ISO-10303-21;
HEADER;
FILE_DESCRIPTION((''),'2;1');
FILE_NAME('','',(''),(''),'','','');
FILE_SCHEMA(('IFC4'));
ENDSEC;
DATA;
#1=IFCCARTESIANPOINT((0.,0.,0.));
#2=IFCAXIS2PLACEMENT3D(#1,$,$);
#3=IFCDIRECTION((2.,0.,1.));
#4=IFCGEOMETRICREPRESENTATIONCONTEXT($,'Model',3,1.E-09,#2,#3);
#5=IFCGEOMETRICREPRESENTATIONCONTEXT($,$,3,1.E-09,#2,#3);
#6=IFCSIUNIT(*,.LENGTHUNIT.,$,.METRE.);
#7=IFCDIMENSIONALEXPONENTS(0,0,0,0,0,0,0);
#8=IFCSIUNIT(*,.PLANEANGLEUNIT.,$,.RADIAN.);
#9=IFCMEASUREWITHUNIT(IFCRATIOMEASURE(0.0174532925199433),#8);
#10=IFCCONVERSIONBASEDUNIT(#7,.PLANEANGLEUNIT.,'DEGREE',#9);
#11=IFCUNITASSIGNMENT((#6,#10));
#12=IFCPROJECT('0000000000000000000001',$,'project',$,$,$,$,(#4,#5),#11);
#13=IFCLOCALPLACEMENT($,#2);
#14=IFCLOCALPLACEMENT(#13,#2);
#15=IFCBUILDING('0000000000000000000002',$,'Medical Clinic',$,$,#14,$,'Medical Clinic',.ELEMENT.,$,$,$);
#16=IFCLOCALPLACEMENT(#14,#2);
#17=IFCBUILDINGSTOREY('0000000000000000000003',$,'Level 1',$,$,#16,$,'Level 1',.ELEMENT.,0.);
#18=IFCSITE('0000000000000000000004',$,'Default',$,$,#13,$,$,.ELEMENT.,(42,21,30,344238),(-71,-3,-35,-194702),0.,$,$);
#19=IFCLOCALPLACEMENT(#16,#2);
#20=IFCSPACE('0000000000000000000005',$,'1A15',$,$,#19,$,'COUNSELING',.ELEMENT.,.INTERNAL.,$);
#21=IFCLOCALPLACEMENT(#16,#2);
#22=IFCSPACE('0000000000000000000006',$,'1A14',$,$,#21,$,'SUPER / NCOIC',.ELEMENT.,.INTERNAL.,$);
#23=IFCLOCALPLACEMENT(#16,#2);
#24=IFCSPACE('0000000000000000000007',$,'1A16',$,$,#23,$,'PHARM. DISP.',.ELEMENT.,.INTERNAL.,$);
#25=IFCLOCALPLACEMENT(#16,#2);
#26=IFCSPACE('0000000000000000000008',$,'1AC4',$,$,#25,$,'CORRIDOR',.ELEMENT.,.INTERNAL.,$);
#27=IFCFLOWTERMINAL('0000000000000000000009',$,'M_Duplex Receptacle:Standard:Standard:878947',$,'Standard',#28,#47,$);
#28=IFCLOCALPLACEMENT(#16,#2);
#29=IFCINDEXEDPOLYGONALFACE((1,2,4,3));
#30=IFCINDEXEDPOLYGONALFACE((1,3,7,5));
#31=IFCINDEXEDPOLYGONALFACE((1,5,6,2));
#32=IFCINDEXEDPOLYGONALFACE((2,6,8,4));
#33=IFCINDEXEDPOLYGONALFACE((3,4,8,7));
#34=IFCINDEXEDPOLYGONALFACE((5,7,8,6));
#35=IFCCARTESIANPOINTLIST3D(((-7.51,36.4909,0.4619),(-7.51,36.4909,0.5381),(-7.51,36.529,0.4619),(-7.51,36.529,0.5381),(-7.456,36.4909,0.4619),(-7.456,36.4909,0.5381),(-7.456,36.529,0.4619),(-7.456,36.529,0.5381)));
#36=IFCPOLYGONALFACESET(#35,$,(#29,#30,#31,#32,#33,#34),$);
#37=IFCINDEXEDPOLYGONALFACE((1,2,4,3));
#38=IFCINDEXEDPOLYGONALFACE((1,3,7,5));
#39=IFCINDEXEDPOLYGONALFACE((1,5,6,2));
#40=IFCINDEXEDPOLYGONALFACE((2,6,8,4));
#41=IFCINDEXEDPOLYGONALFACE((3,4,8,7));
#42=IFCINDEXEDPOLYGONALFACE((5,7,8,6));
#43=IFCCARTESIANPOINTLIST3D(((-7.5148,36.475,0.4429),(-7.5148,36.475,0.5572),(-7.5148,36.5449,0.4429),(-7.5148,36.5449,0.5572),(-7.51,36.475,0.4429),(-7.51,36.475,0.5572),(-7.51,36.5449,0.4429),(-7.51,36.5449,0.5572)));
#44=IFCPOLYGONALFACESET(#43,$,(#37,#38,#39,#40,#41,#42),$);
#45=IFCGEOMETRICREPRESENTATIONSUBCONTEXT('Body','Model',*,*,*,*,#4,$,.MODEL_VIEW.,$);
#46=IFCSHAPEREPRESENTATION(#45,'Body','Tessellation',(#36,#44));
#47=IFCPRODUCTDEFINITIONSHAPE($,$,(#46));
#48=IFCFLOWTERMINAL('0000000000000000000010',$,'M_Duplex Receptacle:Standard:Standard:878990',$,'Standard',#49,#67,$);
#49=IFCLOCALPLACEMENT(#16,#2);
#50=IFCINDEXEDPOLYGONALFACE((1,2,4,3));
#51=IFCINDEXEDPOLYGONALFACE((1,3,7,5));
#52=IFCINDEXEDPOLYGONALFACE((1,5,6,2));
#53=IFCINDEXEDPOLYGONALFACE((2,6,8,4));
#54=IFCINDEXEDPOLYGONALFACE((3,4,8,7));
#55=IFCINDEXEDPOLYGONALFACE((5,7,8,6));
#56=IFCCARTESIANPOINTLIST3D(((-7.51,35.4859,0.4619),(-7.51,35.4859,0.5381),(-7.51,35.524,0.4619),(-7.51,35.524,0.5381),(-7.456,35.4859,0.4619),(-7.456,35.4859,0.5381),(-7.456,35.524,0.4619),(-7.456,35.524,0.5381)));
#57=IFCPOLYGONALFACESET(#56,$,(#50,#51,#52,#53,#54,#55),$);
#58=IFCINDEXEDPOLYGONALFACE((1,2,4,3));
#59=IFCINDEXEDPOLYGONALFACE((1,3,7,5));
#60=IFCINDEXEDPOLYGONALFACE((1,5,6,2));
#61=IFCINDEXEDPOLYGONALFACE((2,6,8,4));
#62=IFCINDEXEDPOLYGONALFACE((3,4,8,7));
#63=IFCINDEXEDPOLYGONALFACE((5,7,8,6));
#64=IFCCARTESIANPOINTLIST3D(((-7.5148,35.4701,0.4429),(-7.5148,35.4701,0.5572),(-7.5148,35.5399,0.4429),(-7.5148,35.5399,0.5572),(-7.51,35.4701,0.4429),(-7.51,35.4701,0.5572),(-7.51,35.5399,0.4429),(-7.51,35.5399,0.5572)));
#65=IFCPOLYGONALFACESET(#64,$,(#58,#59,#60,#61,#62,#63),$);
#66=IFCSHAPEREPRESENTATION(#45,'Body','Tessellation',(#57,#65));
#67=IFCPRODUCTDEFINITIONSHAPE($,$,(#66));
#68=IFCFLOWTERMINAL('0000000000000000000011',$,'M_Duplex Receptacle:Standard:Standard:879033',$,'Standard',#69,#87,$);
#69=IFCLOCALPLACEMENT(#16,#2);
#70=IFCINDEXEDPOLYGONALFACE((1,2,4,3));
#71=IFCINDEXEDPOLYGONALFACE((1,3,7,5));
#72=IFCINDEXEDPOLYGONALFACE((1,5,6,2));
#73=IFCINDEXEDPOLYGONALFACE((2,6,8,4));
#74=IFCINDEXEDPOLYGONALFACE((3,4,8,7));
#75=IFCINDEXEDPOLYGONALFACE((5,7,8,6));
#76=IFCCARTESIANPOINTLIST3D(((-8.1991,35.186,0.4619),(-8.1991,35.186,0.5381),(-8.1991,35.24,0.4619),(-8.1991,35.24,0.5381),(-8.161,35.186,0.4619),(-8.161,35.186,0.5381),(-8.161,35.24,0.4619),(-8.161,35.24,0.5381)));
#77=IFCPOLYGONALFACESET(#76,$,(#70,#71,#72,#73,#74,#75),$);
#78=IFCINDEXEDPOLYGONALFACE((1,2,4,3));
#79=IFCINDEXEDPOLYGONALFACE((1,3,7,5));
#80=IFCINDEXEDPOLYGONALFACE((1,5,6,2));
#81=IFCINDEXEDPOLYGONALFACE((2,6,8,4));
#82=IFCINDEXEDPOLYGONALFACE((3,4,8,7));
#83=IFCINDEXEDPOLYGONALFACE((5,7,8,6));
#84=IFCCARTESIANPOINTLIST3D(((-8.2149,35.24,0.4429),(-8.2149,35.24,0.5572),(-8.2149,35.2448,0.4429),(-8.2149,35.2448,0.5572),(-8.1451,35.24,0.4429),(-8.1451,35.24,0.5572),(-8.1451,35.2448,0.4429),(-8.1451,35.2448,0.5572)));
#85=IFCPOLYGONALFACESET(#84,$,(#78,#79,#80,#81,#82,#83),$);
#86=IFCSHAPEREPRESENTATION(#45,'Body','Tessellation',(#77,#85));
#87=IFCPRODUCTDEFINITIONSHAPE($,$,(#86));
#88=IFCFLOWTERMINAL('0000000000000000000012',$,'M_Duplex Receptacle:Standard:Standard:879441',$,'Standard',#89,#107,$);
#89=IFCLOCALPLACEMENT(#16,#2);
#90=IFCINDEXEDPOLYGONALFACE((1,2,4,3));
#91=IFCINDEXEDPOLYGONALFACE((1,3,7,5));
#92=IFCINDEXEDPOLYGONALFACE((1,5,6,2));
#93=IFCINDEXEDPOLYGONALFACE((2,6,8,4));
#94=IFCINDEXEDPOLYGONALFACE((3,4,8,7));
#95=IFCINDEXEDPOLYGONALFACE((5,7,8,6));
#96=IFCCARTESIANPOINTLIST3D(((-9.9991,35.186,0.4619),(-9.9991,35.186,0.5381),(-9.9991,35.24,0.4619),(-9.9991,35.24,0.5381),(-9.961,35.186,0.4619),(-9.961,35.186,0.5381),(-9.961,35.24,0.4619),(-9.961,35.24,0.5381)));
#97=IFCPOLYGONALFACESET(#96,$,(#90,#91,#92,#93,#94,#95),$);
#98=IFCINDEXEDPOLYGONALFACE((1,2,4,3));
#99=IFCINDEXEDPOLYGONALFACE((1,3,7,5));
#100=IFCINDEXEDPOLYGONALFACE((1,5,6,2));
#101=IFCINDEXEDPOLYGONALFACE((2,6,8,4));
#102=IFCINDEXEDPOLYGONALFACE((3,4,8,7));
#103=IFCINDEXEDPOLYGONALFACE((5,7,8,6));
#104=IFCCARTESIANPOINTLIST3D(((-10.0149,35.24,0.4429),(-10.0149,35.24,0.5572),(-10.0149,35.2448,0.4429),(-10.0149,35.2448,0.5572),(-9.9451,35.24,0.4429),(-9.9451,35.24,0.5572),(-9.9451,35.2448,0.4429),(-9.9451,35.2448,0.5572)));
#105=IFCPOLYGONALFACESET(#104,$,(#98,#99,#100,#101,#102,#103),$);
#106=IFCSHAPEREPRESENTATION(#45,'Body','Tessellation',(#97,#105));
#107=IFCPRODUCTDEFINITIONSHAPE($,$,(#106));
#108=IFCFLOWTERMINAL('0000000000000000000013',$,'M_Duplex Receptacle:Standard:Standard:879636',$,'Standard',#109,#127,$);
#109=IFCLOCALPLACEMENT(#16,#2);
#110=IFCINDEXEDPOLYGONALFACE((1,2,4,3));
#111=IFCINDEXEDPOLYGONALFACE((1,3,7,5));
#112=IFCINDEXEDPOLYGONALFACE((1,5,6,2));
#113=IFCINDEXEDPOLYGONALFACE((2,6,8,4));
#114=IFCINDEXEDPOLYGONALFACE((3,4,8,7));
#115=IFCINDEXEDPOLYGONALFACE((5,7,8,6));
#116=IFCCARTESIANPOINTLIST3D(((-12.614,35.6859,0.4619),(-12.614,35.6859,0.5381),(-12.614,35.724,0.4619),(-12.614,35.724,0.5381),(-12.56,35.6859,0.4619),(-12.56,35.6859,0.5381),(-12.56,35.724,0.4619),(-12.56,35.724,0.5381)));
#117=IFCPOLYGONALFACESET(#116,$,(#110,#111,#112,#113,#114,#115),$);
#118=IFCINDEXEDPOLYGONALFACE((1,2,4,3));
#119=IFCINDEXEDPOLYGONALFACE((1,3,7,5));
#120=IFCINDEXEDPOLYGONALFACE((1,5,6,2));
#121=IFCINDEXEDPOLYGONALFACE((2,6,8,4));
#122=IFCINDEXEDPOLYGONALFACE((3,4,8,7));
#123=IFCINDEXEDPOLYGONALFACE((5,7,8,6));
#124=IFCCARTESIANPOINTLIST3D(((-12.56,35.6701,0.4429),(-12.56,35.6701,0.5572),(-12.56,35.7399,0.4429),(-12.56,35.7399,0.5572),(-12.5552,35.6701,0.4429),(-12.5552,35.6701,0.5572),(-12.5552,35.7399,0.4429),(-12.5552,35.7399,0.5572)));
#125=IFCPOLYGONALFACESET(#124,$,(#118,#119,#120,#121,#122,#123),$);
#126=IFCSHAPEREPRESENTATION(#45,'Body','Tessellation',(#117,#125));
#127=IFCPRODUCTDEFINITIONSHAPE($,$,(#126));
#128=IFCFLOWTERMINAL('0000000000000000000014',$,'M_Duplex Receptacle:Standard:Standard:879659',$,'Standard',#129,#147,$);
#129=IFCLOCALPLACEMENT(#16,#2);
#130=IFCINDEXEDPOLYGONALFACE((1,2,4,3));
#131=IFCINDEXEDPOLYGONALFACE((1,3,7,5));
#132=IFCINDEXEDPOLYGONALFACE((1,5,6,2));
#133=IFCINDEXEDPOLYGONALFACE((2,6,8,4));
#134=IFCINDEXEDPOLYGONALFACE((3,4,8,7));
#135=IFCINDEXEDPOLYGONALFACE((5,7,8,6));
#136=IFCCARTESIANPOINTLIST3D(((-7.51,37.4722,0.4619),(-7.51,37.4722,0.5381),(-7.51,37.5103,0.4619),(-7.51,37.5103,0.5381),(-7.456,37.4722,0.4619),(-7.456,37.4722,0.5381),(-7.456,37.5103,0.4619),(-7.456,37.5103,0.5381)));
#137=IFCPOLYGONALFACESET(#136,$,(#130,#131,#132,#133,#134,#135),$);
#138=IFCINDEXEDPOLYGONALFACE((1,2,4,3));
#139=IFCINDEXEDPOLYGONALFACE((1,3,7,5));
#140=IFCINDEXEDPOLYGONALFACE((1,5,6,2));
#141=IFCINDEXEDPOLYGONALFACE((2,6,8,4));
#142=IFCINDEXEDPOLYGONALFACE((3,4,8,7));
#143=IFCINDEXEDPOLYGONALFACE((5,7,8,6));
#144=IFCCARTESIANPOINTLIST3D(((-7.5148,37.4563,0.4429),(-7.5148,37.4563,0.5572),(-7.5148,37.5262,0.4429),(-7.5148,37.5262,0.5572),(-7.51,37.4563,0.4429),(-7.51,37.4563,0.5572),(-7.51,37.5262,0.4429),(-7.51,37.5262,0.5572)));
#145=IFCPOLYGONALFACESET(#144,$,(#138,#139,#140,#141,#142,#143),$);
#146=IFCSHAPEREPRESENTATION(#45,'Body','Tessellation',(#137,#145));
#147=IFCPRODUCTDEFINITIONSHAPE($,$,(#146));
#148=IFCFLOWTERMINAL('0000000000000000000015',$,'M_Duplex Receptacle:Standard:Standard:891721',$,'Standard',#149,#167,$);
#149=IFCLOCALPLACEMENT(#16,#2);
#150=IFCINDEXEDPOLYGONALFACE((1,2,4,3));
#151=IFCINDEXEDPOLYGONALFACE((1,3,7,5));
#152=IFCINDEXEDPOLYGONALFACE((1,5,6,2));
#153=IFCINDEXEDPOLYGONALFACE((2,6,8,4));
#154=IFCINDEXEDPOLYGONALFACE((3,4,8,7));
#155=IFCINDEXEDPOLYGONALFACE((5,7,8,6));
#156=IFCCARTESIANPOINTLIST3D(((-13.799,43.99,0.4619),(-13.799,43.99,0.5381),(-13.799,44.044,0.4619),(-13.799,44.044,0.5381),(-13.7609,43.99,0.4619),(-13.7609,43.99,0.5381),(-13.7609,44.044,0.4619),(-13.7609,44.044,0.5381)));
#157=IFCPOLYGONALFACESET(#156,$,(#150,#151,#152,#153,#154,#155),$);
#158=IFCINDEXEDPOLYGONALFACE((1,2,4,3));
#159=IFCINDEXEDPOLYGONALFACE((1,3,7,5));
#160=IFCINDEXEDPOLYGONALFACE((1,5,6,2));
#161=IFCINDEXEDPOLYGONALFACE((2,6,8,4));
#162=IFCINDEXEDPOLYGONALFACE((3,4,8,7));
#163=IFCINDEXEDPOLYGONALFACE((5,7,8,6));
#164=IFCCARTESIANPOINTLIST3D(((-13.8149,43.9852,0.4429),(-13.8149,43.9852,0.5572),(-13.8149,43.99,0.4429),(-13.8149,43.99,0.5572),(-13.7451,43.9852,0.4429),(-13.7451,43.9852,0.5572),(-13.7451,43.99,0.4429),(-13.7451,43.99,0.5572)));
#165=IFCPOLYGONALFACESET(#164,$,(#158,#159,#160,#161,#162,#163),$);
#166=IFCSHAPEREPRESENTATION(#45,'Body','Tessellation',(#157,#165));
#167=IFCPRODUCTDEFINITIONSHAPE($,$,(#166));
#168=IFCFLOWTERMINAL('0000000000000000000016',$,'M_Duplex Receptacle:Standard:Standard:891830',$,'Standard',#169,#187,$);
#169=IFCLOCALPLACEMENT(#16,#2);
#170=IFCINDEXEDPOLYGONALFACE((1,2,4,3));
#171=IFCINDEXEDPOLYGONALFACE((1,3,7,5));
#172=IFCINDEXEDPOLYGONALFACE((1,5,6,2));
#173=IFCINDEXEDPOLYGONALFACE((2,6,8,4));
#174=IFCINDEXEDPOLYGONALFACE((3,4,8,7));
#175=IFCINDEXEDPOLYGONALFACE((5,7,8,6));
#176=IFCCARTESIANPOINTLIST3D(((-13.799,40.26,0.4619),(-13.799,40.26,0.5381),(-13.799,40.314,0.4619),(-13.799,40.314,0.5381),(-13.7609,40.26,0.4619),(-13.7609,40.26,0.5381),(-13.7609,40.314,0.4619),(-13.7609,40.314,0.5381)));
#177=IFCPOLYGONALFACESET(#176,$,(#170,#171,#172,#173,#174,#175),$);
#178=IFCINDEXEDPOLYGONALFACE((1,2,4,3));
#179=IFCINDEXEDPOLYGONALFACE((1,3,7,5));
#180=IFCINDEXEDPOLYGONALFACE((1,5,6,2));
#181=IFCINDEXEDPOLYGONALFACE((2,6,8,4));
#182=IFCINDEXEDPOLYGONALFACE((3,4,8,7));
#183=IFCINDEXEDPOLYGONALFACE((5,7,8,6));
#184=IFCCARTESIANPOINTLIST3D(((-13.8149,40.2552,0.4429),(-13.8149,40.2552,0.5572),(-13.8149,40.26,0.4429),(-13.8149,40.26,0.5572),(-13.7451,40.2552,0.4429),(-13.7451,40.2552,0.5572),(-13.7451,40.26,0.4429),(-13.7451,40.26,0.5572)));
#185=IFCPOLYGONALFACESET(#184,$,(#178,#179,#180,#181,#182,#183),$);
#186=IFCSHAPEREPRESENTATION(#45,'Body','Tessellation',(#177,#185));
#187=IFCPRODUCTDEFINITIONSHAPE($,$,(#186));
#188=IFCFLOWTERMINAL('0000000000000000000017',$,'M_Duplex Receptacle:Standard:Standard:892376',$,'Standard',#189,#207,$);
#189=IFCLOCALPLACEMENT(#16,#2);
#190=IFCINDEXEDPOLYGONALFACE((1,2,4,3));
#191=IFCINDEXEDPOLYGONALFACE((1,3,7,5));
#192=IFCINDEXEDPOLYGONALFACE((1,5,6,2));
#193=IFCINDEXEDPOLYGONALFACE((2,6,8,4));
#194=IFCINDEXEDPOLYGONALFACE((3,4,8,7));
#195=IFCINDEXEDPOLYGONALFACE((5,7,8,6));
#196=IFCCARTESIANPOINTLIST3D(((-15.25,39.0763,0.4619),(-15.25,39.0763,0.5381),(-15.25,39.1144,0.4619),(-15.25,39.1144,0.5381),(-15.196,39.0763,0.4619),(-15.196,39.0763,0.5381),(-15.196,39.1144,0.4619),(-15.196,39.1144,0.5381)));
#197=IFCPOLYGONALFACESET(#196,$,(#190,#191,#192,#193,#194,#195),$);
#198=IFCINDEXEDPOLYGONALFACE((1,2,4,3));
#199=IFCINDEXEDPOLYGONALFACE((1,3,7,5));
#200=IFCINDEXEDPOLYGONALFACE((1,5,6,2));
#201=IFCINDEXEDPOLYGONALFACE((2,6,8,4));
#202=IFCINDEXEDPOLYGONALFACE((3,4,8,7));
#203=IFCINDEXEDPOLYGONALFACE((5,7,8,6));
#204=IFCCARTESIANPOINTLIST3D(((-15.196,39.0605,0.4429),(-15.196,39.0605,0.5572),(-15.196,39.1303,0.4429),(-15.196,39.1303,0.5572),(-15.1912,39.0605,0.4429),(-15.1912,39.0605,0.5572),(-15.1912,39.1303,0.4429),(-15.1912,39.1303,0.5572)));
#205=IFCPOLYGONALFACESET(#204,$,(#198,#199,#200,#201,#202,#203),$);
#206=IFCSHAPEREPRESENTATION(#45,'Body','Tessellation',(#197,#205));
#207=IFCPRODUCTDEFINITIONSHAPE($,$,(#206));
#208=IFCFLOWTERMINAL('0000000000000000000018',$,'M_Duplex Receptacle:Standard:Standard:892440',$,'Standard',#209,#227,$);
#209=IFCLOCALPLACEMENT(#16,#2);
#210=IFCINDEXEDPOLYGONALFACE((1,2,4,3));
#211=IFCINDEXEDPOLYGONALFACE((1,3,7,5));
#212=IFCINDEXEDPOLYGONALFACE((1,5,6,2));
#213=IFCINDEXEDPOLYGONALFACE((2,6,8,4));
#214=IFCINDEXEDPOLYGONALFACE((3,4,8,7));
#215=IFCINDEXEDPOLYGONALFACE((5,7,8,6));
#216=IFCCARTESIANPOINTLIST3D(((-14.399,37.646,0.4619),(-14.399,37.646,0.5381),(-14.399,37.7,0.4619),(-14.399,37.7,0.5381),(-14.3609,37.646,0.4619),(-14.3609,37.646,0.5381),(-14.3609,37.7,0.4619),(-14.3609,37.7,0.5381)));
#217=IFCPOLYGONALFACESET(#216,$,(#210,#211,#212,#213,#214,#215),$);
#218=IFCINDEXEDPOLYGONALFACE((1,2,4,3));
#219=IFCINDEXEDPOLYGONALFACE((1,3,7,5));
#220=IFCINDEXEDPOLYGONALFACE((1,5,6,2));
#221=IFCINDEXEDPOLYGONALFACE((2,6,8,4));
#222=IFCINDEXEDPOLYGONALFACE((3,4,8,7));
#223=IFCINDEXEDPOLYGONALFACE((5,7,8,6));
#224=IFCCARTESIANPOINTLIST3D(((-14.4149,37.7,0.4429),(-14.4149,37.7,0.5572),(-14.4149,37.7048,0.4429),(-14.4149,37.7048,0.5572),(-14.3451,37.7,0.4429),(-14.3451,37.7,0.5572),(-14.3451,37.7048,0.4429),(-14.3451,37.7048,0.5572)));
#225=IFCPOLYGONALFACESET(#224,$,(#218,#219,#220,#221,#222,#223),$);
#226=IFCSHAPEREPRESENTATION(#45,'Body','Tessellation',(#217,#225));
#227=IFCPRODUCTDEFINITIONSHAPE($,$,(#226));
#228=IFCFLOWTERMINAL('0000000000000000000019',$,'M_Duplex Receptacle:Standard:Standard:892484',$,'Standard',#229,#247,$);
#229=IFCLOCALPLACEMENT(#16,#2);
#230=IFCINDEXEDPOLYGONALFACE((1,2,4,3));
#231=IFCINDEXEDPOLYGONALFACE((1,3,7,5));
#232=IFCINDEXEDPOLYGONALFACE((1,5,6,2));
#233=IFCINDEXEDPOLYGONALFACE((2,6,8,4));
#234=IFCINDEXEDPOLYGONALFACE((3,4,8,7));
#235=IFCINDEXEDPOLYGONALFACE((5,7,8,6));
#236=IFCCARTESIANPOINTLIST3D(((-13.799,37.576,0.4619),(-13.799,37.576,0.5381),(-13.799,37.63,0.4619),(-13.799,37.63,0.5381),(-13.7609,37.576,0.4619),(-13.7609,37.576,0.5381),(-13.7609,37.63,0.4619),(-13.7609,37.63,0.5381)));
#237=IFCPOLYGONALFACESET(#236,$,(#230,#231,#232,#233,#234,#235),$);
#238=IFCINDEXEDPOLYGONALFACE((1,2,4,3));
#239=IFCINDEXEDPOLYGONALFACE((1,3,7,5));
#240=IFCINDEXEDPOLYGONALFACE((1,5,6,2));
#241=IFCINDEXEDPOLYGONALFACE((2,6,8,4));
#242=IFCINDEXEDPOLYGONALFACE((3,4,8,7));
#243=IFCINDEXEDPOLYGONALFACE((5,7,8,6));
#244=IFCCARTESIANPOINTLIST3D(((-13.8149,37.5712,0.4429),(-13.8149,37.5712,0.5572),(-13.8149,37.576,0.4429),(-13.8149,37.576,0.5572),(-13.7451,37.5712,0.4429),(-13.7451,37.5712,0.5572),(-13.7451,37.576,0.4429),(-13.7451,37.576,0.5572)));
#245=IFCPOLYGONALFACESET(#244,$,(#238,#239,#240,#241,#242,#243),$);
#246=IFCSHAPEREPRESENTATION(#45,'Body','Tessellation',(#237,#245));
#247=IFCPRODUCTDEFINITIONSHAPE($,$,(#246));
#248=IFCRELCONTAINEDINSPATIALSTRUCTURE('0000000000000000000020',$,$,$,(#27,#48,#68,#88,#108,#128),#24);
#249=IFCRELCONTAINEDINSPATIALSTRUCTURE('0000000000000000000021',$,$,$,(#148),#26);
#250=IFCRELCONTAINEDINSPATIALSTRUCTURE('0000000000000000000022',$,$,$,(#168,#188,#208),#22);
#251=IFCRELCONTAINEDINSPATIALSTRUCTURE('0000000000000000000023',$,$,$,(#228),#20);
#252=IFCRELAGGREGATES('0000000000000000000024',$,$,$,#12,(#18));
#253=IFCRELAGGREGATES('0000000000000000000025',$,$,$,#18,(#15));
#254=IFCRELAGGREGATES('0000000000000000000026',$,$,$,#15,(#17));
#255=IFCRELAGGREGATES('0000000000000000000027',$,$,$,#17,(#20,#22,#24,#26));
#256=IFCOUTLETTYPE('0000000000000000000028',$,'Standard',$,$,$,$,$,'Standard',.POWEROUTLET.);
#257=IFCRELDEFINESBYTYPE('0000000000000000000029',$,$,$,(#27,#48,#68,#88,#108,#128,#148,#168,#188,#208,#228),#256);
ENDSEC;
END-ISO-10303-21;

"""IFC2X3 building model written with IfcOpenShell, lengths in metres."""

from ifc_helpers import new_model, entity, si_unit, converted_unit, direction, frame, frame_2d, origin, origin_2d_with_axis, place, context, subcontext, project, spatial, rectangle, extrude, source, transform, mapped, type_object, type_shapes, element, save


model = new_model("IFC2X3")

# Units and contexts
model_context = context("Model", 3, precision=1e-09, world=origin(), true_north=direction((2.0, 0.0, 1.0)))
context_of_model = context(None, 3, precision=1e-09, world=origin(), true_north=direction((2.0, 0.0, 1.0)))
body_context = subcontext(model_context, "Body", "Model", "MODEL_VIEW")
ifc_project = project(units=[si_unit("LENGTHUNIT", "METRE"), converted_unit("PLANEANGLEUNIT", "DEGREE", entity("IfcRatioMeasure", 0.0174532925199433), si_unit("PLANEANGLEUNIT", "RADIAN"), dimensions=[0, 0, 0, 0, 0, 0, 0])], contexts=[model_context, context_of_model])

# Site, building, storey
site_placement = place(None, origin())
site = spatial("IfcSite", under=ifc_project, at=site_placement, Name="Default", CompositionType="ELEMENT", RefLatitude=(42, 21, 30, 344238), RefLongitude=(-71, -3, -35, -194702), RefElevation=0.0)
building_placement = place(site_placement, origin())
building = spatial("IfcBuilding", under=site, at=building_placement, Name="Medical Clinic", LongName="Medical Clinic", CompositionType="ELEMENT")
storey_placement = place(building_placement, origin())
storey = spatial("IfcBuildingStorey", under=building, at=storey_placement, Name="Level 1", LongName="Level 1", CompositionType="ELEMENT", Elevation=0.0)

# Shared definitions
space_1_placement = place(storey_placement, origin())
space_1 = spatial("IfcSpace", under=storey, at=space_1_placement, Name="1A15", LongName="COUNSELING", CompositionType="ELEMENT", InteriorOrExteriorSpace="INTERNAL")

# Shared definitions
space_2_placement = place(storey_placement, origin())
space_2 = spatial("IfcSpace", under=storey, at=space_2_placement, Name="1A14", LongName="SUPER / NCOIC", CompositionType="ELEMENT", InteriorOrExteriorSpace="INTERNAL")

# Shared definitions
space_3_placement = place(storey_placement, origin())
space_3 = spatial("IfcSpace", under=storey, at=space_3_placement, Name="1A16", LongName="PHARM. DISP.", CompositionType="ELEMENT", InteriorOrExteriorSpace="INTERNAL")

# Flow terminals
outlet_type = type_object("IfcOutletType", Name="Standard", ElementType="Standard", PredefinedType="POWEROUTLET")
shared_shape_1 = source(origin(), body_context, "Body", "SweptSolid", [
    extrude(rectangle(XDim=0.0381, YDim=0.0762, at=origin_2d_with_axis()), frame((0.0, 0.0, -0.054), z_axis=(0.0, 0.0, 1.0), x_axis=(-1.0, 0.0, 0.0)), (0.0, 0.0, 1.0), 0.054),
    extrude(rectangle(XDim=0.0698, YDim=0.1143, at=frame_2d((0.0, 0.0), x_axis=(1.0, 0.0))), frame((0.0, 0.0, 0.0), z_axis=(0.0, 0.0, 1.0), x_axis=(-1.0, 0.0, 0.0)), (0.0, 0.0, 1.0), 0.0048),
])
type_shapes(outlet_type, [shared_shape_1])
for number, where, z_axis, x_axis, name in (
    (1, (-7.51, 36.5099, 0.5), (-1.0, 0.0, 0.0), (0.0, -1.0, 0.0), "M_Duplex Receptacle:Standard:Standard:878947"),
    (2, (-7.51, 35.505, 0.5), (-1.0, 0.0, 0.0), (0.0, -1.0, 0.0), "M_Duplex Receptacle:Standard:Standard:878990"),
    (3, (-8.18, 35.24, 0.5), (0.0, 1.0, 0.0), (-1.0, 0.0, 0.0), "M_Duplex Receptacle:Standard:Standard:879033"),
    (4, (-9.98, 35.24, 0.5), (0.0, 1.0, 0.0), (-1.0, 0.0, 0.0), "M_Duplex Receptacle:Standard:Standard:879441"),
    (5, (-12.56, 35.705, 0.5), (1.0, 0.0, 0.0), (0.0, 1.0, 0.0), "M_Duplex Receptacle:Standard:Standard:879636"),
    (6, (-7.51, 37.4912, 0.5), (-1.0, 0.0, 0.0), (0.0, -1.0, 0.0), "M_Duplex Receptacle:Standard:Standard:879659"),
):
    element("IfcFlowTerminal", number, at=place(space_3_placement, frame(where, z_axis=z_axis, x_axis=x_axis)), inside=space_3, type_object=outlet_type, Name=name, ObjectType="Standard", context=body_context, shape_type="MappedRepresentation", body=[
        mapped(shared_shape_1, transform((0.0, 0.0, 0.0), scale=1.0)),
    ])

# Shared definitions
space_4_placement = place(storey_placement, origin())
space_4 = spatial("IfcSpace", under=storey, at=space_4_placement, Name="1AC4", LongName="CORRIDOR", CompositionType="ELEMENT", InteriorOrExteriorSpace="INTERNAL")

# Flow terminals
flow_terminal_1_placement = place(space_4_placement, frame((-13.78, 43.99, 0.5), z_axis=(0.0, -1.0, 0.0), x_axis=(1.0, 0.0, 0.0)))
element("IfcFlowTerminal", 7, at=flow_terminal_1_placement, inside=space_4, type_object=outlet_type, Name="M_Duplex Receptacle:Standard:Standard:891721", ObjectType="Standard", context=body_context, shape_type="MappedRepresentation", body=[
    mapped(shared_shape_1, transform((0.0, 0.0, 0.0), scale=1.0)),
])
for number, where, z_axis, x_axis, name in (
    (8, (-13.78, 40.26, 0.5), (0.0, -1.0, 0.0), (1.0, 0.0, 0.0), "M_Duplex Receptacle:Standard:Standard:891830"),
    (9, (-15.196, 39.0954, 0.5), (1.0, 0.0, 0.0), (0.0, 1.0, 0.0), "M_Duplex Receptacle:Standard:Standard:892376"),
    (10, (-14.38, 37.7, 0.5), (0.0, 1.0, 0.0), (-1.0, 0.0, 0.0), "M_Duplex Receptacle:Standard:Standard:892440"),
):
    element("IfcFlowTerminal", number, at=place(space_2_placement, frame(where, z_axis=z_axis, x_axis=x_axis)), inside=space_2, type_object=outlet_type, Name=name, ObjectType="Standard", context=body_context, shape_type="MappedRepresentation", body=[
        mapped(shared_shape_1, transform((0.0, 0.0, 0.0), scale=1.0)),
    ])
for number, where, z_axis, x_axis, name in (
    (11, (-13.78, 37.576, 0.5), (0.0, -1.0, 0.0), (1.0, 0.0, 0.0), "M_Duplex Receptacle:Standard:Standard:892484"),
):
    element("IfcFlowTerminal", number, at=place(space_1_placement, frame(where, z_axis=z_axis, x_axis=x_axis)), inside=space_1, type_object=outlet_type, Name=name, ObjectType="Standard", context=body_context, shape_type="MappedRepresentation", body=[
        mapped(shared_shape_1, transform((0.0, 0.0, 0.0), scale=1.0)),
    ])

save(model, "model.ifc")
